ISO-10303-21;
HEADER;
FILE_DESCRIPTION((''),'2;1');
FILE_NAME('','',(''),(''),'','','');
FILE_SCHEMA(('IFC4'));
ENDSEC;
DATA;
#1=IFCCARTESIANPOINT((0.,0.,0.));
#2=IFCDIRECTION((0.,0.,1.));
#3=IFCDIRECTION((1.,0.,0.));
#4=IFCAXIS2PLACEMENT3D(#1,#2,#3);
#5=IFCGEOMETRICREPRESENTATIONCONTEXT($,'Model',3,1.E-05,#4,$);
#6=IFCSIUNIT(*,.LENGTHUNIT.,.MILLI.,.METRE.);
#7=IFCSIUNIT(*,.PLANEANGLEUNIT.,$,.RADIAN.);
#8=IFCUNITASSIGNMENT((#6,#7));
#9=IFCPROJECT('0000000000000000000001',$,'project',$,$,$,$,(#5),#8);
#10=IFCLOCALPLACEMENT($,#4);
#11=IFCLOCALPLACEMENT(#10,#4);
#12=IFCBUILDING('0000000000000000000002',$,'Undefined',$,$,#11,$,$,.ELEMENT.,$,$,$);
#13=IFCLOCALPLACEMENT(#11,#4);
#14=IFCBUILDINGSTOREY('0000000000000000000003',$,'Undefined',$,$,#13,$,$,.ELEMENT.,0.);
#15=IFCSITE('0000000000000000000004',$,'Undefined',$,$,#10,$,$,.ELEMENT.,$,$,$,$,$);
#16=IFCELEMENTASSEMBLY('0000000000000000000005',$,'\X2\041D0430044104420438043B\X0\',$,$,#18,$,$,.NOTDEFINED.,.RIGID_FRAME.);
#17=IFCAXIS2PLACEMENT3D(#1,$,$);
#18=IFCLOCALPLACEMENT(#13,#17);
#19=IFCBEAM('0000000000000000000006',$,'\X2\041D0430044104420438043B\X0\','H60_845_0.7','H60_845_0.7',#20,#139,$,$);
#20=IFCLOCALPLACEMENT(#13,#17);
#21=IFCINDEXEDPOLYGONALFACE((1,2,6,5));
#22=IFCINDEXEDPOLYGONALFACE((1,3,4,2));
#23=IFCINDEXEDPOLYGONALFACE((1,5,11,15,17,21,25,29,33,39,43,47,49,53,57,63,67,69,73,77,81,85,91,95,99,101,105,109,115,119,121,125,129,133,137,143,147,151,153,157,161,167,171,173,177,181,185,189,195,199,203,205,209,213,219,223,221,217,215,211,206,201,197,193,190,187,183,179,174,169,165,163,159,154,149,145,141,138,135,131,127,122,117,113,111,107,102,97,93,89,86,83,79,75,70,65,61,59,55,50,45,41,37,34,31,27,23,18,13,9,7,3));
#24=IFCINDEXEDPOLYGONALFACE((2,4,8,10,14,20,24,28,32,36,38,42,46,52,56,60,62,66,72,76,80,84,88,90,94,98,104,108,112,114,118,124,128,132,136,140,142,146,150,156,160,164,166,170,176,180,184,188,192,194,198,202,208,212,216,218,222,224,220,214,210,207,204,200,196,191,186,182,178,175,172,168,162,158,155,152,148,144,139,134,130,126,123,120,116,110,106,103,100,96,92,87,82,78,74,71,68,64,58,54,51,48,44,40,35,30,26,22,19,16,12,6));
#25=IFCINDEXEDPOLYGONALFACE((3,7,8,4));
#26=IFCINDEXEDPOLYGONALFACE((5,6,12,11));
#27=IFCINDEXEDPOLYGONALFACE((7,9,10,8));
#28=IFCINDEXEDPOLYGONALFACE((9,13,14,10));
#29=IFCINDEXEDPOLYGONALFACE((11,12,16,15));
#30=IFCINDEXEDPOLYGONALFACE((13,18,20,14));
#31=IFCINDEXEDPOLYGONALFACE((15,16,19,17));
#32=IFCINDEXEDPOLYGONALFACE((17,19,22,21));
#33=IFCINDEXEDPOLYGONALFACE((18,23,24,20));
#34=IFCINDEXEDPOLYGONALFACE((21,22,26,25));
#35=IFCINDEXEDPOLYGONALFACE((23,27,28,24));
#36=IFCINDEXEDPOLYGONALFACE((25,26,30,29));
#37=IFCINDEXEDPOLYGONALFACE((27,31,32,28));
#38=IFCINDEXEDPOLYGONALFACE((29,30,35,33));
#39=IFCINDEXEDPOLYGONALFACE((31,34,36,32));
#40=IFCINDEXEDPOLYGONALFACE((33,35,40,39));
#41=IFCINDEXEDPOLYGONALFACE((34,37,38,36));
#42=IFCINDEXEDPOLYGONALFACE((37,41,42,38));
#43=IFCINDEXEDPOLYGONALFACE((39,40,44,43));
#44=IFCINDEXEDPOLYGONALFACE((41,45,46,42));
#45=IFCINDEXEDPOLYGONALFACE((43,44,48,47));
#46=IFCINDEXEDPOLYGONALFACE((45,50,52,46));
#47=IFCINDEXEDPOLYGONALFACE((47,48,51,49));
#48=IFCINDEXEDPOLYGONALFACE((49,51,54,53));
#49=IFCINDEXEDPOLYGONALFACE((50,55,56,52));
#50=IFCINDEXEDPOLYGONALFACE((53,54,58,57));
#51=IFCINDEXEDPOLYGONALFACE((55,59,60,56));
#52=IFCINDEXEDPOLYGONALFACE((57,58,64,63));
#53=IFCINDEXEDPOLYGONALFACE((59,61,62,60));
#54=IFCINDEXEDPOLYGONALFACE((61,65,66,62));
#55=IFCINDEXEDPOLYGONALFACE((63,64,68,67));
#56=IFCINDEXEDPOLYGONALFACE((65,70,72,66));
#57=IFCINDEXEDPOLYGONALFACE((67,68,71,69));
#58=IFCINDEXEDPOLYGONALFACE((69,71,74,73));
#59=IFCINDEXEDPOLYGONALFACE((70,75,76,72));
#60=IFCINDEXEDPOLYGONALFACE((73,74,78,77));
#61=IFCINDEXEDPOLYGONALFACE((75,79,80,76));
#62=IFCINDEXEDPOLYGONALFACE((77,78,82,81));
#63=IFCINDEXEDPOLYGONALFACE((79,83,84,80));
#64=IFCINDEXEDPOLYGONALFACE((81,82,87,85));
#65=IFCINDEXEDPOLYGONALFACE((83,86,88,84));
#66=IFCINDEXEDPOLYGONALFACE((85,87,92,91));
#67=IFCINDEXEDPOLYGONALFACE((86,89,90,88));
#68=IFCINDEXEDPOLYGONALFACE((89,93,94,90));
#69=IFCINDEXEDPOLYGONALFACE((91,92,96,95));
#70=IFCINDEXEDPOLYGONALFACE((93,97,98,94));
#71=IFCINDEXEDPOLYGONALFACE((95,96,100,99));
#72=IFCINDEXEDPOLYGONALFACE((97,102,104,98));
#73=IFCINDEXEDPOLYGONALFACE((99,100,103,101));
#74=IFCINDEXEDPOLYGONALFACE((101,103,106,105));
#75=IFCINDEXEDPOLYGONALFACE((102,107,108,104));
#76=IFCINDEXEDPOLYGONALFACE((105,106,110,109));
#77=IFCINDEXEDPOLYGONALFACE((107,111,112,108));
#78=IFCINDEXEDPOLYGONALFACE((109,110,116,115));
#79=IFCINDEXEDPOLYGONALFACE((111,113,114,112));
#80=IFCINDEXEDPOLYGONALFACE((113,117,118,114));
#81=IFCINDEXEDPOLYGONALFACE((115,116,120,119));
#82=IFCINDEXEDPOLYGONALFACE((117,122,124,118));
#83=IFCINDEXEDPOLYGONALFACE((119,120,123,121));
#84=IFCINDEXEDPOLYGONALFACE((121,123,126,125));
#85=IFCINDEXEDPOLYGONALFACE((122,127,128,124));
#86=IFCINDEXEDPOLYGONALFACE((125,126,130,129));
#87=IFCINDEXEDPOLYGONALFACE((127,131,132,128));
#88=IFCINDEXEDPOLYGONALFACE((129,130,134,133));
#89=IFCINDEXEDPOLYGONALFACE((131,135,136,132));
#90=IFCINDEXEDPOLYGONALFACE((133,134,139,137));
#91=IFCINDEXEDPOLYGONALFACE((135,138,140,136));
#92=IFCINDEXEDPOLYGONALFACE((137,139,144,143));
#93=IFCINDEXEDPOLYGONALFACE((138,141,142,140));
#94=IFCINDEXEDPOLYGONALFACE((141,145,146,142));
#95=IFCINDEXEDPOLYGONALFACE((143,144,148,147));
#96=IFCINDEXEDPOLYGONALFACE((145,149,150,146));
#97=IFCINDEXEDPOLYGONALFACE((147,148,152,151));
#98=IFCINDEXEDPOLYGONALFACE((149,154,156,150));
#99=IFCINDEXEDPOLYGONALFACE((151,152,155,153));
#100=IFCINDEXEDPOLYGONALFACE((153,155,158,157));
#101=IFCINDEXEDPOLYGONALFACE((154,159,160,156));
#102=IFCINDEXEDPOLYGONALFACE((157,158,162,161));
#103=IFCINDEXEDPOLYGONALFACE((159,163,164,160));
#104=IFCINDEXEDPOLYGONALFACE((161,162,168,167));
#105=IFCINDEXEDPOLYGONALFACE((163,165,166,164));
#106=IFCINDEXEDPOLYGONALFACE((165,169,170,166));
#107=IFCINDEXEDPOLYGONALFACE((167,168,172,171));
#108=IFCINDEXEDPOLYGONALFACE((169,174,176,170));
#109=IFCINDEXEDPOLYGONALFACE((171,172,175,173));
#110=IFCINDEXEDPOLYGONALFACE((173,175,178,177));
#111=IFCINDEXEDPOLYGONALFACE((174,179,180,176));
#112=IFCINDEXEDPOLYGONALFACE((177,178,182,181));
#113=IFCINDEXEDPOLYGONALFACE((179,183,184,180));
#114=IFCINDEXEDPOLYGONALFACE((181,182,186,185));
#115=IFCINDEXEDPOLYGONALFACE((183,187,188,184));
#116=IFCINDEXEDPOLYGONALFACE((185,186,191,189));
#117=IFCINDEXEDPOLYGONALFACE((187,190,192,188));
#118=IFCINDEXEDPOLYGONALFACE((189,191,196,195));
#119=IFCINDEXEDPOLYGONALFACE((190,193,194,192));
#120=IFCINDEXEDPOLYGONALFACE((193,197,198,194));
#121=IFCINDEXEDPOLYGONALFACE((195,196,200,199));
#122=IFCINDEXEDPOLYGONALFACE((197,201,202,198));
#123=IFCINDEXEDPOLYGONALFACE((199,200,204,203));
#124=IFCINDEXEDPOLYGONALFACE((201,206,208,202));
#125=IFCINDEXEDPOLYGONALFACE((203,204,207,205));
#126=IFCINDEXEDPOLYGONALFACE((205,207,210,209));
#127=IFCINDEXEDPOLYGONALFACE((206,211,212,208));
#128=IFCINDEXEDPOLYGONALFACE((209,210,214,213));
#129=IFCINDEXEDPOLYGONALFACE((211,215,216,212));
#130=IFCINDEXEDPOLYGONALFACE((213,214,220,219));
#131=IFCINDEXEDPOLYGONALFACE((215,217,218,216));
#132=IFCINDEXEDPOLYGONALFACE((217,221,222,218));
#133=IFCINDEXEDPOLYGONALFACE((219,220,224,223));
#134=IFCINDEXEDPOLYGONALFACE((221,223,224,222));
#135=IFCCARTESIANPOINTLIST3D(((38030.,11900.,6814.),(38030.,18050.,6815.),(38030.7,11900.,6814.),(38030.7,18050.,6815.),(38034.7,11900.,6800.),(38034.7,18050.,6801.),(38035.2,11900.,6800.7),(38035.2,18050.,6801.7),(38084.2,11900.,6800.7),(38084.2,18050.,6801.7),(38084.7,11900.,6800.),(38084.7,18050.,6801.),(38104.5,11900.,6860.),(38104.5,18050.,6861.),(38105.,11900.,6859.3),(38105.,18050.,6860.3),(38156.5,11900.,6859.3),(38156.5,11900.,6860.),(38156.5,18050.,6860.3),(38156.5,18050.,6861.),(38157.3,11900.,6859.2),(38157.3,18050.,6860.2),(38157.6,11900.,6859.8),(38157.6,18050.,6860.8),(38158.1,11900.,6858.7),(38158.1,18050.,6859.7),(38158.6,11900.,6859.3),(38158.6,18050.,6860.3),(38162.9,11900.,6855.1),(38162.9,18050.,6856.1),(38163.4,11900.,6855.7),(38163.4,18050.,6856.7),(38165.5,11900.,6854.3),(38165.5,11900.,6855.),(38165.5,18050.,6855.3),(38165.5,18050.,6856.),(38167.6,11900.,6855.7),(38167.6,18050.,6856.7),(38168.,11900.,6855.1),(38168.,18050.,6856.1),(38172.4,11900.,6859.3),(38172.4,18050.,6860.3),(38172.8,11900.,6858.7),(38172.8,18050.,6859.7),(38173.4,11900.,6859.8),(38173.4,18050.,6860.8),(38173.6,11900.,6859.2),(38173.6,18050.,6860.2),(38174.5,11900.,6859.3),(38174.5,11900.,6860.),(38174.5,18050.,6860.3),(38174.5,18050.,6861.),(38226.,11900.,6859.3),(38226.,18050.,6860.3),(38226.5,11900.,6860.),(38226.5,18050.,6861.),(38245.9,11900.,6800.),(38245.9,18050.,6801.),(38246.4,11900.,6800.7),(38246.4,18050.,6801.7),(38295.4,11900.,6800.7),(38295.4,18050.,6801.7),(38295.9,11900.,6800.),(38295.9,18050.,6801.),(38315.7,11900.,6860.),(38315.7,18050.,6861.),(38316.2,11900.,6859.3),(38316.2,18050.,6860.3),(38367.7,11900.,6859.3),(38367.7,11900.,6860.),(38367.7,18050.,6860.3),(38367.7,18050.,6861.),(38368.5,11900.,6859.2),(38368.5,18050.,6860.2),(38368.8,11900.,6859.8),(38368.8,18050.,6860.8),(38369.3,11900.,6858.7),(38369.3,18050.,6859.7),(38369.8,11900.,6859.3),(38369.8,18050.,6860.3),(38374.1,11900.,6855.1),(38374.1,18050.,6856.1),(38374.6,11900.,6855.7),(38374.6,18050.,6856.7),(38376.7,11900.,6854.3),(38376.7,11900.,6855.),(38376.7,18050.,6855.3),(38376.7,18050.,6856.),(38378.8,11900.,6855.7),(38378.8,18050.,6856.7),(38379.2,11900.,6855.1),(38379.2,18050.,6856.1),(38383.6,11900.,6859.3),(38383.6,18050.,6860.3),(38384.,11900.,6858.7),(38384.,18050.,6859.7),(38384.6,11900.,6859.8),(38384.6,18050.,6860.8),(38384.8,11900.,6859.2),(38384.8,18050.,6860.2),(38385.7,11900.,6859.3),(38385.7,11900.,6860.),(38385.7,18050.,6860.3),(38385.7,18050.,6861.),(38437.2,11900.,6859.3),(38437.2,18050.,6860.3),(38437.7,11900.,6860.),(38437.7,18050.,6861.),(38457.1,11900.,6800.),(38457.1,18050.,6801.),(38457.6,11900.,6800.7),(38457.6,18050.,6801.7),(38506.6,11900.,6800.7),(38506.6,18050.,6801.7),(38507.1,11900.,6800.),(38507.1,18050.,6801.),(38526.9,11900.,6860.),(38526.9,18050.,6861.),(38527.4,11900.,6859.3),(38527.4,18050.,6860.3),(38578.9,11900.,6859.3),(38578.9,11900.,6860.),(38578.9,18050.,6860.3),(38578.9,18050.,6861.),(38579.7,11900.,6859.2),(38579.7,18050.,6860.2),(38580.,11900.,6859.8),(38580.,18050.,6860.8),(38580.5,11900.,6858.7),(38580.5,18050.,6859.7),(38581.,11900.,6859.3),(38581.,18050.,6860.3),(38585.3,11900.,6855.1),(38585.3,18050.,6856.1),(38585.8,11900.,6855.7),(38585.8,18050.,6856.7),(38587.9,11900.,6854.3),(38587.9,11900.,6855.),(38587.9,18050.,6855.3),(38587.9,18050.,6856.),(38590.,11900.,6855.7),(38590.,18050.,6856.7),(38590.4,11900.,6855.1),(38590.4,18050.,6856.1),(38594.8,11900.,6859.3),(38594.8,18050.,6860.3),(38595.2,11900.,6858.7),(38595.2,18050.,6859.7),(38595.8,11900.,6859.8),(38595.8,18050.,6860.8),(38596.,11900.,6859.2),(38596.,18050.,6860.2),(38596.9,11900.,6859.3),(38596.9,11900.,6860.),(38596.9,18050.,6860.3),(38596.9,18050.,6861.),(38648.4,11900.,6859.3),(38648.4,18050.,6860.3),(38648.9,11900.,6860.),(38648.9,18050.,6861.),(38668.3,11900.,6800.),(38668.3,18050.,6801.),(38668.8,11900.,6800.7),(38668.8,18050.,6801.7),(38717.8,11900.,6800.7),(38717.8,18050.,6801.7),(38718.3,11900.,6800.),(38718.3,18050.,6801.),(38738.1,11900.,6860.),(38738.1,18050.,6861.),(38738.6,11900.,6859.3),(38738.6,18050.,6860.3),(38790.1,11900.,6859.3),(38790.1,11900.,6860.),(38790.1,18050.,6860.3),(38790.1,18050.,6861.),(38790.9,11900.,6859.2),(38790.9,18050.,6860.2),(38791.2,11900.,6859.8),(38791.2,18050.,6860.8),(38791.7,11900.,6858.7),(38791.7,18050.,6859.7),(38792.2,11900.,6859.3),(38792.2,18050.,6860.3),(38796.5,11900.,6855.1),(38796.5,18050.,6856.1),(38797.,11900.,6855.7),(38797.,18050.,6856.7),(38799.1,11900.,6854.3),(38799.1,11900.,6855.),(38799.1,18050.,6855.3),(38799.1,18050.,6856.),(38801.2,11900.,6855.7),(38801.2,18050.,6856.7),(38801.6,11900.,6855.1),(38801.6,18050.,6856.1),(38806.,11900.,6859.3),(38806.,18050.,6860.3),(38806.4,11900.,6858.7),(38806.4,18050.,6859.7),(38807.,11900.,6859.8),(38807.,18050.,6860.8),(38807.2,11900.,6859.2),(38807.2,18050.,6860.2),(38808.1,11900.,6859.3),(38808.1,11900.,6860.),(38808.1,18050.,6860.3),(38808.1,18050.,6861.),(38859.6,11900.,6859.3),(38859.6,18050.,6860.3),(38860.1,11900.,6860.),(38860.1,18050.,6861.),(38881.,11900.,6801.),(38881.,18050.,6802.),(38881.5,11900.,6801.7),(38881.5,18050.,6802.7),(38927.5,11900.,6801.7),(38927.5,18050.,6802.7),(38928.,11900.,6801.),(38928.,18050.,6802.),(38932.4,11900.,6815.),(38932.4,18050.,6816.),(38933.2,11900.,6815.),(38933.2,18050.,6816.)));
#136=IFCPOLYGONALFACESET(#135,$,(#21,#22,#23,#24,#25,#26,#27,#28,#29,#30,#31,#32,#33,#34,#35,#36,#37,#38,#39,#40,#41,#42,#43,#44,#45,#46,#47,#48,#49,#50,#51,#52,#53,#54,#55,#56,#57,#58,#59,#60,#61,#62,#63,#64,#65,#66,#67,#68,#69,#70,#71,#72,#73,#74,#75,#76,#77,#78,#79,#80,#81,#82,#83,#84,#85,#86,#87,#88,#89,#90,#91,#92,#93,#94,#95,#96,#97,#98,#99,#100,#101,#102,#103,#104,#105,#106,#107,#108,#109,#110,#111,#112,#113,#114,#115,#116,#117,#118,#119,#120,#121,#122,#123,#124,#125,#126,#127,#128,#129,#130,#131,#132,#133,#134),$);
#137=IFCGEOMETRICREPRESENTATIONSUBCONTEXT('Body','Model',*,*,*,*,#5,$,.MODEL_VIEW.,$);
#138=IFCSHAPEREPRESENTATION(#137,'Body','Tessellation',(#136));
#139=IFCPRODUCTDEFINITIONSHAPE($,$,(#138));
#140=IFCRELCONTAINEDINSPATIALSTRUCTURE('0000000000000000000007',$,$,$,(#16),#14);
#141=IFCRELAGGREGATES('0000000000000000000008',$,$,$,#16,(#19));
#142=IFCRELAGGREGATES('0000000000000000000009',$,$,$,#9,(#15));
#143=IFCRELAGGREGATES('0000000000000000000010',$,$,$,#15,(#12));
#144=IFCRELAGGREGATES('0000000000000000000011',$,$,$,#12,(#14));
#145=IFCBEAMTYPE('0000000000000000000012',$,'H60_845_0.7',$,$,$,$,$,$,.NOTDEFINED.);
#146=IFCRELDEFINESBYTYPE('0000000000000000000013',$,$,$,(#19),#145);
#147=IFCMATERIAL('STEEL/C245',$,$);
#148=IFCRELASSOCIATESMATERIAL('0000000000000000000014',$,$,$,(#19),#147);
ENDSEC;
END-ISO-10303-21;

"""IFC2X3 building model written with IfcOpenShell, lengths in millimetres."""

from ifc_helpers import new_model, si_unit, frame, origin_with_axes, place, context, subcontext, project, spatial, polyline, outline, extrude, material, type_object, element, aggregate, save


model = new_model("IFC2X3")

# Units and contexts
model_context = context("Model", 3, precision=1e-05, world=origin_with_axes())
body_context = subcontext(model_context, "Body", "Model", "MODEL_VIEW")
ifc_project = project(units=[si_unit("LENGTHUNIT", "METRE", prefix="MILLI"), si_unit("PLANEANGLEUNIT", "RADIAN")], contexts=[model_context])

# Site, building, storey
site_placement = place(None, origin_with_axes())
site = spatial("IfcSite", under=ifc_project, at=site_placement, Name="Undefined", CompositionType="ELEMENT")
building_placement = place(site_placement, origin_with_axes())
building = spatial("IfcBuilding", under=site, at=building_placement, Name="Undefined", CompositionType="ELEMENT")
storey_placement = place(building_placement, origin_with_axes())
storey = spatial("IfcBuildingStorey", under=building, at=storey_placement, Name="Undefined", CompositionType="ELEMENT", Elevation=0.0)

# Element assembly, beam
ifc_material_1 = material(Name="STEEL/C245")
assembly_1_placement = place(storey_placement, origin_with_axes())
assembly_1 = element("IfcElementAssembly", 1, at=assembly_1_placement, inside=storey, Name="Настил", AssemblyPlace="NOTDEFINED", PredefinedType="RIGID_FRAME")
beam_type_1 = type_object("IfcBeamType", Name="H60_845_0.7", PredefinedType="NOTDEFINED")
beam_1_placement = place(assembly_1_placement, frame((38481.2, 18050.0, 6831.0), z_axis=(0.0, -0.000163, 1.0), x_axis=(0.0, -1.0, -0.000163)))
beam_1 = element("IfcBeam", 2, at=beam_1_placement, type_object=beam_type_1, material=ifc_material_1, Name="Настил", Description="H60_845_0.7", ObjectType="H60_845_0.7", context=body_context, shape_type="SweptSolid", body=[
    extrude(outline(polyline([(-399.8, -29.0), (-446.8, -29.0), (-452.0, -15.0), (-451.2, -15.0), (-446.3, -28.3), (-400.3, -28.3), (-378.9, 30.0), (-326.9, 30.0), (-325.7, 29.8), (-324.7, 29.3), (-320.0, 25.7), (-317.9, 25.0), (-315.8, 25.7), (-311.0, 29.3), (-310.0, 29.8), (-308.9, 30.0), (-256.9, 30.0), (-236.6, -29.3), (-187.6, -29.3), (-167.7, 30.0), (-115.7, 30.0), (-114.5, 29.8), (-113.5, 29.3), (-108.8, 25.7), (-106.7, 25.0), (-104.6, 25.7), (-99.7, 29.3), (-98.8, 29.8), (-97.7, 30.0), (-45.7, 30.0), (-25.4, -29.3), (23.6, -29.3), (43.5, 30.0), (95.5, 30.0), (96.7, 29.8), (97.7, 29.3), (102.4, 25.7), (104.5, 25.0), (106.6, 25.7), (111.4, 29.3), (112.4, 29.8), (113.5, 30.0), (165.5, 30.0), (185.8, -29.3), (234.8, -29.3), (254.7, 30.0), (306.7, 30.0), (307.9, 29.8), (308.9, 29.3), (313.6, 25.7), (315.7, 25.0), (317.8, 25.7), (322.6, 29.3), (323.6, 29.8), (324.7, 30.0), (376.7, 30.0), (397.0, -29.3), (446.0, -29.3), (450.5, -16.0), (451.2, -16.0), (446.5, -30.0), (396.5, -30.0), (376.2, 29.3), (324.7, 29.3), (323.9, 29.2), (323.1, 28.7), (318.3, 25.1), (315.7, 24.3), (313.2, 25.1), (308.4, 28.7), (307.6, 29.2), (306.7, 29.3), (255.2, 29.3), (235.3, -30.0), (185.3, -30.0), (165.0, 29.3), (113.5, 29.3), (112.7, 29.2), (111.9, 28.7), (107.1, 25.1), (104.5, 24.3), (102.0, 25.1), (97.2, 28.7), (96.4, 29.2), (95.5, 29.3), (44.0, 29.3), (24.1, -30.0), (-25.9, -30.0), (-46.2, 29.3), (-97.7, 29.3), (-98.5, 29.2), (-99.3, 28.7), (-104.1, 25.1), (-106.7, 24.3), (-109.2, 25.1), (-114.0, 28.7), (-114.8, 29.2), (-115.7, 29.3), (-167.2, 29.3), (-187.1, -30.0), (-237.1, -30.0), (-257.4, 29.3), (-308.9, 29.3), (-309.7, 29.2), (-310.5, 28.7), (-315.3, 25.1), (-317.9, 24.3), (-320.4, 25.1), (-325.2, 28.7), (-326.0, 29.2), (-326.9, 29.3), (-378.4, 29.3), (-399.8, -29.0)])), frame((6150.0, 0.0, 0.0), z_axis=(-1.0, 0.0, 0.0), x_axis=(0.0, -1.0, 0.0)), (0.0, 0.0, 1.0), 6150.0),
])
aggregate(assembly_1, [beam_1])

save(model, "model.ifc")
